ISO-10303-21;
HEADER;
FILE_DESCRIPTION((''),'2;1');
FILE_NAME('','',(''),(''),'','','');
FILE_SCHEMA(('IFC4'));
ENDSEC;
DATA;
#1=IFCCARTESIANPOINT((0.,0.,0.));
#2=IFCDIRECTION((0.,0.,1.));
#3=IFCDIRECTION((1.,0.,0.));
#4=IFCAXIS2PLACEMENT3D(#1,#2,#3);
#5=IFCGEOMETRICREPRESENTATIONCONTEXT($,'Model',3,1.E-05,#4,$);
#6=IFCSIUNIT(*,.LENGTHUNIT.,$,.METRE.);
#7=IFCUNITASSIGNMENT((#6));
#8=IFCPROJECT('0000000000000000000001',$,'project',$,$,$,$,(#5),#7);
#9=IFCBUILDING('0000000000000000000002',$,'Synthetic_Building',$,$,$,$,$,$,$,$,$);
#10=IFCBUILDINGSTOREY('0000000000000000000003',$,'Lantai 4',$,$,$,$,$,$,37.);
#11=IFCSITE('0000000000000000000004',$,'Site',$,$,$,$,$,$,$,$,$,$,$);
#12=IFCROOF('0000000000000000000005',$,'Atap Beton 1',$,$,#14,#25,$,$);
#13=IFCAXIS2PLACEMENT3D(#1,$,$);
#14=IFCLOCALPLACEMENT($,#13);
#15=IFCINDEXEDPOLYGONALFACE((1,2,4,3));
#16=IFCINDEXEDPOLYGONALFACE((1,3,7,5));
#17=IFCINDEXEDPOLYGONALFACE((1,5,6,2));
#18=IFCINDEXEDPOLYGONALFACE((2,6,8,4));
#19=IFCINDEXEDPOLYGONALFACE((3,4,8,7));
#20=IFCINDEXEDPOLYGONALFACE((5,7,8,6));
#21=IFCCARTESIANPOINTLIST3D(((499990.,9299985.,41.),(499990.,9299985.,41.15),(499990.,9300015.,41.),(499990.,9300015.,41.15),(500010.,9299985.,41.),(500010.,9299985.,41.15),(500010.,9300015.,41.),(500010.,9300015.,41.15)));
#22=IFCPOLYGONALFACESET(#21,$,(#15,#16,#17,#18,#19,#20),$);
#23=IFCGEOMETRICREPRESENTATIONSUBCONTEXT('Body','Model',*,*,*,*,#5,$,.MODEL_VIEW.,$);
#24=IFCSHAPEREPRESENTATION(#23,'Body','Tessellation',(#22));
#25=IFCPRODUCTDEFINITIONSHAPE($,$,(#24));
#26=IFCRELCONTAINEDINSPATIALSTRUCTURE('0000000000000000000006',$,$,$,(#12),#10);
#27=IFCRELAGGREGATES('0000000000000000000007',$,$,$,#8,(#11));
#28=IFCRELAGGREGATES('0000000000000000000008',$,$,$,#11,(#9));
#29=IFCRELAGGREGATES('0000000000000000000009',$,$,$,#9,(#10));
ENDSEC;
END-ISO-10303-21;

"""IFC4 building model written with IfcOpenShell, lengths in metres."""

from ifc_helpers import new_model, si_unit, frame, origin_with_axes, place, context, subcontext, project, spatial, polyline, outline, extrude, element, save


model = new_model("IFC4")

# Units and contexts
model_context = context("Model", 3, precision=1e-05, world=origin_with_axes())
body_context = subcontext(model_context, "Body", "Model", "MODEL_VIEW")
ifc_project = project(units=[si_unit("LENGTHUNIT", "METRE")], contexts=[model_context])

# Site, building, storey
site = spatial("IfcSite", under=ifc_project, Name="Site")
building = spatial("IfcBuilding", under=site, Name="Synthetic_Building")
storey = spatial("IfcBuildingStorey", under=building, Name="Lantai 4", Elevation=37.0)

# Roof
roof_placement = place(None, origin_with_axes())
element("IfcRoof", 1, at=roof_placement, inside=storey, Name="Atap Beton 1", context=body_context, shape_type="SweptSolid", body=[
    extrude(outline(polyline([(499990.0, 9299985.0), (500010.0, 9299985.0), (500010.0, 9300015.0), (499990.0, 9300015.0), (499990.0, 9299985.0)])), frame((0.0, 0.0, 41.0), z_axis=(0.0, 0.0, 1.0), x_axis=(1.0, 0.0, 0.0)), (0.0, 0.0, 1.0), 0.15),
])

save(model, "model.ifc")
